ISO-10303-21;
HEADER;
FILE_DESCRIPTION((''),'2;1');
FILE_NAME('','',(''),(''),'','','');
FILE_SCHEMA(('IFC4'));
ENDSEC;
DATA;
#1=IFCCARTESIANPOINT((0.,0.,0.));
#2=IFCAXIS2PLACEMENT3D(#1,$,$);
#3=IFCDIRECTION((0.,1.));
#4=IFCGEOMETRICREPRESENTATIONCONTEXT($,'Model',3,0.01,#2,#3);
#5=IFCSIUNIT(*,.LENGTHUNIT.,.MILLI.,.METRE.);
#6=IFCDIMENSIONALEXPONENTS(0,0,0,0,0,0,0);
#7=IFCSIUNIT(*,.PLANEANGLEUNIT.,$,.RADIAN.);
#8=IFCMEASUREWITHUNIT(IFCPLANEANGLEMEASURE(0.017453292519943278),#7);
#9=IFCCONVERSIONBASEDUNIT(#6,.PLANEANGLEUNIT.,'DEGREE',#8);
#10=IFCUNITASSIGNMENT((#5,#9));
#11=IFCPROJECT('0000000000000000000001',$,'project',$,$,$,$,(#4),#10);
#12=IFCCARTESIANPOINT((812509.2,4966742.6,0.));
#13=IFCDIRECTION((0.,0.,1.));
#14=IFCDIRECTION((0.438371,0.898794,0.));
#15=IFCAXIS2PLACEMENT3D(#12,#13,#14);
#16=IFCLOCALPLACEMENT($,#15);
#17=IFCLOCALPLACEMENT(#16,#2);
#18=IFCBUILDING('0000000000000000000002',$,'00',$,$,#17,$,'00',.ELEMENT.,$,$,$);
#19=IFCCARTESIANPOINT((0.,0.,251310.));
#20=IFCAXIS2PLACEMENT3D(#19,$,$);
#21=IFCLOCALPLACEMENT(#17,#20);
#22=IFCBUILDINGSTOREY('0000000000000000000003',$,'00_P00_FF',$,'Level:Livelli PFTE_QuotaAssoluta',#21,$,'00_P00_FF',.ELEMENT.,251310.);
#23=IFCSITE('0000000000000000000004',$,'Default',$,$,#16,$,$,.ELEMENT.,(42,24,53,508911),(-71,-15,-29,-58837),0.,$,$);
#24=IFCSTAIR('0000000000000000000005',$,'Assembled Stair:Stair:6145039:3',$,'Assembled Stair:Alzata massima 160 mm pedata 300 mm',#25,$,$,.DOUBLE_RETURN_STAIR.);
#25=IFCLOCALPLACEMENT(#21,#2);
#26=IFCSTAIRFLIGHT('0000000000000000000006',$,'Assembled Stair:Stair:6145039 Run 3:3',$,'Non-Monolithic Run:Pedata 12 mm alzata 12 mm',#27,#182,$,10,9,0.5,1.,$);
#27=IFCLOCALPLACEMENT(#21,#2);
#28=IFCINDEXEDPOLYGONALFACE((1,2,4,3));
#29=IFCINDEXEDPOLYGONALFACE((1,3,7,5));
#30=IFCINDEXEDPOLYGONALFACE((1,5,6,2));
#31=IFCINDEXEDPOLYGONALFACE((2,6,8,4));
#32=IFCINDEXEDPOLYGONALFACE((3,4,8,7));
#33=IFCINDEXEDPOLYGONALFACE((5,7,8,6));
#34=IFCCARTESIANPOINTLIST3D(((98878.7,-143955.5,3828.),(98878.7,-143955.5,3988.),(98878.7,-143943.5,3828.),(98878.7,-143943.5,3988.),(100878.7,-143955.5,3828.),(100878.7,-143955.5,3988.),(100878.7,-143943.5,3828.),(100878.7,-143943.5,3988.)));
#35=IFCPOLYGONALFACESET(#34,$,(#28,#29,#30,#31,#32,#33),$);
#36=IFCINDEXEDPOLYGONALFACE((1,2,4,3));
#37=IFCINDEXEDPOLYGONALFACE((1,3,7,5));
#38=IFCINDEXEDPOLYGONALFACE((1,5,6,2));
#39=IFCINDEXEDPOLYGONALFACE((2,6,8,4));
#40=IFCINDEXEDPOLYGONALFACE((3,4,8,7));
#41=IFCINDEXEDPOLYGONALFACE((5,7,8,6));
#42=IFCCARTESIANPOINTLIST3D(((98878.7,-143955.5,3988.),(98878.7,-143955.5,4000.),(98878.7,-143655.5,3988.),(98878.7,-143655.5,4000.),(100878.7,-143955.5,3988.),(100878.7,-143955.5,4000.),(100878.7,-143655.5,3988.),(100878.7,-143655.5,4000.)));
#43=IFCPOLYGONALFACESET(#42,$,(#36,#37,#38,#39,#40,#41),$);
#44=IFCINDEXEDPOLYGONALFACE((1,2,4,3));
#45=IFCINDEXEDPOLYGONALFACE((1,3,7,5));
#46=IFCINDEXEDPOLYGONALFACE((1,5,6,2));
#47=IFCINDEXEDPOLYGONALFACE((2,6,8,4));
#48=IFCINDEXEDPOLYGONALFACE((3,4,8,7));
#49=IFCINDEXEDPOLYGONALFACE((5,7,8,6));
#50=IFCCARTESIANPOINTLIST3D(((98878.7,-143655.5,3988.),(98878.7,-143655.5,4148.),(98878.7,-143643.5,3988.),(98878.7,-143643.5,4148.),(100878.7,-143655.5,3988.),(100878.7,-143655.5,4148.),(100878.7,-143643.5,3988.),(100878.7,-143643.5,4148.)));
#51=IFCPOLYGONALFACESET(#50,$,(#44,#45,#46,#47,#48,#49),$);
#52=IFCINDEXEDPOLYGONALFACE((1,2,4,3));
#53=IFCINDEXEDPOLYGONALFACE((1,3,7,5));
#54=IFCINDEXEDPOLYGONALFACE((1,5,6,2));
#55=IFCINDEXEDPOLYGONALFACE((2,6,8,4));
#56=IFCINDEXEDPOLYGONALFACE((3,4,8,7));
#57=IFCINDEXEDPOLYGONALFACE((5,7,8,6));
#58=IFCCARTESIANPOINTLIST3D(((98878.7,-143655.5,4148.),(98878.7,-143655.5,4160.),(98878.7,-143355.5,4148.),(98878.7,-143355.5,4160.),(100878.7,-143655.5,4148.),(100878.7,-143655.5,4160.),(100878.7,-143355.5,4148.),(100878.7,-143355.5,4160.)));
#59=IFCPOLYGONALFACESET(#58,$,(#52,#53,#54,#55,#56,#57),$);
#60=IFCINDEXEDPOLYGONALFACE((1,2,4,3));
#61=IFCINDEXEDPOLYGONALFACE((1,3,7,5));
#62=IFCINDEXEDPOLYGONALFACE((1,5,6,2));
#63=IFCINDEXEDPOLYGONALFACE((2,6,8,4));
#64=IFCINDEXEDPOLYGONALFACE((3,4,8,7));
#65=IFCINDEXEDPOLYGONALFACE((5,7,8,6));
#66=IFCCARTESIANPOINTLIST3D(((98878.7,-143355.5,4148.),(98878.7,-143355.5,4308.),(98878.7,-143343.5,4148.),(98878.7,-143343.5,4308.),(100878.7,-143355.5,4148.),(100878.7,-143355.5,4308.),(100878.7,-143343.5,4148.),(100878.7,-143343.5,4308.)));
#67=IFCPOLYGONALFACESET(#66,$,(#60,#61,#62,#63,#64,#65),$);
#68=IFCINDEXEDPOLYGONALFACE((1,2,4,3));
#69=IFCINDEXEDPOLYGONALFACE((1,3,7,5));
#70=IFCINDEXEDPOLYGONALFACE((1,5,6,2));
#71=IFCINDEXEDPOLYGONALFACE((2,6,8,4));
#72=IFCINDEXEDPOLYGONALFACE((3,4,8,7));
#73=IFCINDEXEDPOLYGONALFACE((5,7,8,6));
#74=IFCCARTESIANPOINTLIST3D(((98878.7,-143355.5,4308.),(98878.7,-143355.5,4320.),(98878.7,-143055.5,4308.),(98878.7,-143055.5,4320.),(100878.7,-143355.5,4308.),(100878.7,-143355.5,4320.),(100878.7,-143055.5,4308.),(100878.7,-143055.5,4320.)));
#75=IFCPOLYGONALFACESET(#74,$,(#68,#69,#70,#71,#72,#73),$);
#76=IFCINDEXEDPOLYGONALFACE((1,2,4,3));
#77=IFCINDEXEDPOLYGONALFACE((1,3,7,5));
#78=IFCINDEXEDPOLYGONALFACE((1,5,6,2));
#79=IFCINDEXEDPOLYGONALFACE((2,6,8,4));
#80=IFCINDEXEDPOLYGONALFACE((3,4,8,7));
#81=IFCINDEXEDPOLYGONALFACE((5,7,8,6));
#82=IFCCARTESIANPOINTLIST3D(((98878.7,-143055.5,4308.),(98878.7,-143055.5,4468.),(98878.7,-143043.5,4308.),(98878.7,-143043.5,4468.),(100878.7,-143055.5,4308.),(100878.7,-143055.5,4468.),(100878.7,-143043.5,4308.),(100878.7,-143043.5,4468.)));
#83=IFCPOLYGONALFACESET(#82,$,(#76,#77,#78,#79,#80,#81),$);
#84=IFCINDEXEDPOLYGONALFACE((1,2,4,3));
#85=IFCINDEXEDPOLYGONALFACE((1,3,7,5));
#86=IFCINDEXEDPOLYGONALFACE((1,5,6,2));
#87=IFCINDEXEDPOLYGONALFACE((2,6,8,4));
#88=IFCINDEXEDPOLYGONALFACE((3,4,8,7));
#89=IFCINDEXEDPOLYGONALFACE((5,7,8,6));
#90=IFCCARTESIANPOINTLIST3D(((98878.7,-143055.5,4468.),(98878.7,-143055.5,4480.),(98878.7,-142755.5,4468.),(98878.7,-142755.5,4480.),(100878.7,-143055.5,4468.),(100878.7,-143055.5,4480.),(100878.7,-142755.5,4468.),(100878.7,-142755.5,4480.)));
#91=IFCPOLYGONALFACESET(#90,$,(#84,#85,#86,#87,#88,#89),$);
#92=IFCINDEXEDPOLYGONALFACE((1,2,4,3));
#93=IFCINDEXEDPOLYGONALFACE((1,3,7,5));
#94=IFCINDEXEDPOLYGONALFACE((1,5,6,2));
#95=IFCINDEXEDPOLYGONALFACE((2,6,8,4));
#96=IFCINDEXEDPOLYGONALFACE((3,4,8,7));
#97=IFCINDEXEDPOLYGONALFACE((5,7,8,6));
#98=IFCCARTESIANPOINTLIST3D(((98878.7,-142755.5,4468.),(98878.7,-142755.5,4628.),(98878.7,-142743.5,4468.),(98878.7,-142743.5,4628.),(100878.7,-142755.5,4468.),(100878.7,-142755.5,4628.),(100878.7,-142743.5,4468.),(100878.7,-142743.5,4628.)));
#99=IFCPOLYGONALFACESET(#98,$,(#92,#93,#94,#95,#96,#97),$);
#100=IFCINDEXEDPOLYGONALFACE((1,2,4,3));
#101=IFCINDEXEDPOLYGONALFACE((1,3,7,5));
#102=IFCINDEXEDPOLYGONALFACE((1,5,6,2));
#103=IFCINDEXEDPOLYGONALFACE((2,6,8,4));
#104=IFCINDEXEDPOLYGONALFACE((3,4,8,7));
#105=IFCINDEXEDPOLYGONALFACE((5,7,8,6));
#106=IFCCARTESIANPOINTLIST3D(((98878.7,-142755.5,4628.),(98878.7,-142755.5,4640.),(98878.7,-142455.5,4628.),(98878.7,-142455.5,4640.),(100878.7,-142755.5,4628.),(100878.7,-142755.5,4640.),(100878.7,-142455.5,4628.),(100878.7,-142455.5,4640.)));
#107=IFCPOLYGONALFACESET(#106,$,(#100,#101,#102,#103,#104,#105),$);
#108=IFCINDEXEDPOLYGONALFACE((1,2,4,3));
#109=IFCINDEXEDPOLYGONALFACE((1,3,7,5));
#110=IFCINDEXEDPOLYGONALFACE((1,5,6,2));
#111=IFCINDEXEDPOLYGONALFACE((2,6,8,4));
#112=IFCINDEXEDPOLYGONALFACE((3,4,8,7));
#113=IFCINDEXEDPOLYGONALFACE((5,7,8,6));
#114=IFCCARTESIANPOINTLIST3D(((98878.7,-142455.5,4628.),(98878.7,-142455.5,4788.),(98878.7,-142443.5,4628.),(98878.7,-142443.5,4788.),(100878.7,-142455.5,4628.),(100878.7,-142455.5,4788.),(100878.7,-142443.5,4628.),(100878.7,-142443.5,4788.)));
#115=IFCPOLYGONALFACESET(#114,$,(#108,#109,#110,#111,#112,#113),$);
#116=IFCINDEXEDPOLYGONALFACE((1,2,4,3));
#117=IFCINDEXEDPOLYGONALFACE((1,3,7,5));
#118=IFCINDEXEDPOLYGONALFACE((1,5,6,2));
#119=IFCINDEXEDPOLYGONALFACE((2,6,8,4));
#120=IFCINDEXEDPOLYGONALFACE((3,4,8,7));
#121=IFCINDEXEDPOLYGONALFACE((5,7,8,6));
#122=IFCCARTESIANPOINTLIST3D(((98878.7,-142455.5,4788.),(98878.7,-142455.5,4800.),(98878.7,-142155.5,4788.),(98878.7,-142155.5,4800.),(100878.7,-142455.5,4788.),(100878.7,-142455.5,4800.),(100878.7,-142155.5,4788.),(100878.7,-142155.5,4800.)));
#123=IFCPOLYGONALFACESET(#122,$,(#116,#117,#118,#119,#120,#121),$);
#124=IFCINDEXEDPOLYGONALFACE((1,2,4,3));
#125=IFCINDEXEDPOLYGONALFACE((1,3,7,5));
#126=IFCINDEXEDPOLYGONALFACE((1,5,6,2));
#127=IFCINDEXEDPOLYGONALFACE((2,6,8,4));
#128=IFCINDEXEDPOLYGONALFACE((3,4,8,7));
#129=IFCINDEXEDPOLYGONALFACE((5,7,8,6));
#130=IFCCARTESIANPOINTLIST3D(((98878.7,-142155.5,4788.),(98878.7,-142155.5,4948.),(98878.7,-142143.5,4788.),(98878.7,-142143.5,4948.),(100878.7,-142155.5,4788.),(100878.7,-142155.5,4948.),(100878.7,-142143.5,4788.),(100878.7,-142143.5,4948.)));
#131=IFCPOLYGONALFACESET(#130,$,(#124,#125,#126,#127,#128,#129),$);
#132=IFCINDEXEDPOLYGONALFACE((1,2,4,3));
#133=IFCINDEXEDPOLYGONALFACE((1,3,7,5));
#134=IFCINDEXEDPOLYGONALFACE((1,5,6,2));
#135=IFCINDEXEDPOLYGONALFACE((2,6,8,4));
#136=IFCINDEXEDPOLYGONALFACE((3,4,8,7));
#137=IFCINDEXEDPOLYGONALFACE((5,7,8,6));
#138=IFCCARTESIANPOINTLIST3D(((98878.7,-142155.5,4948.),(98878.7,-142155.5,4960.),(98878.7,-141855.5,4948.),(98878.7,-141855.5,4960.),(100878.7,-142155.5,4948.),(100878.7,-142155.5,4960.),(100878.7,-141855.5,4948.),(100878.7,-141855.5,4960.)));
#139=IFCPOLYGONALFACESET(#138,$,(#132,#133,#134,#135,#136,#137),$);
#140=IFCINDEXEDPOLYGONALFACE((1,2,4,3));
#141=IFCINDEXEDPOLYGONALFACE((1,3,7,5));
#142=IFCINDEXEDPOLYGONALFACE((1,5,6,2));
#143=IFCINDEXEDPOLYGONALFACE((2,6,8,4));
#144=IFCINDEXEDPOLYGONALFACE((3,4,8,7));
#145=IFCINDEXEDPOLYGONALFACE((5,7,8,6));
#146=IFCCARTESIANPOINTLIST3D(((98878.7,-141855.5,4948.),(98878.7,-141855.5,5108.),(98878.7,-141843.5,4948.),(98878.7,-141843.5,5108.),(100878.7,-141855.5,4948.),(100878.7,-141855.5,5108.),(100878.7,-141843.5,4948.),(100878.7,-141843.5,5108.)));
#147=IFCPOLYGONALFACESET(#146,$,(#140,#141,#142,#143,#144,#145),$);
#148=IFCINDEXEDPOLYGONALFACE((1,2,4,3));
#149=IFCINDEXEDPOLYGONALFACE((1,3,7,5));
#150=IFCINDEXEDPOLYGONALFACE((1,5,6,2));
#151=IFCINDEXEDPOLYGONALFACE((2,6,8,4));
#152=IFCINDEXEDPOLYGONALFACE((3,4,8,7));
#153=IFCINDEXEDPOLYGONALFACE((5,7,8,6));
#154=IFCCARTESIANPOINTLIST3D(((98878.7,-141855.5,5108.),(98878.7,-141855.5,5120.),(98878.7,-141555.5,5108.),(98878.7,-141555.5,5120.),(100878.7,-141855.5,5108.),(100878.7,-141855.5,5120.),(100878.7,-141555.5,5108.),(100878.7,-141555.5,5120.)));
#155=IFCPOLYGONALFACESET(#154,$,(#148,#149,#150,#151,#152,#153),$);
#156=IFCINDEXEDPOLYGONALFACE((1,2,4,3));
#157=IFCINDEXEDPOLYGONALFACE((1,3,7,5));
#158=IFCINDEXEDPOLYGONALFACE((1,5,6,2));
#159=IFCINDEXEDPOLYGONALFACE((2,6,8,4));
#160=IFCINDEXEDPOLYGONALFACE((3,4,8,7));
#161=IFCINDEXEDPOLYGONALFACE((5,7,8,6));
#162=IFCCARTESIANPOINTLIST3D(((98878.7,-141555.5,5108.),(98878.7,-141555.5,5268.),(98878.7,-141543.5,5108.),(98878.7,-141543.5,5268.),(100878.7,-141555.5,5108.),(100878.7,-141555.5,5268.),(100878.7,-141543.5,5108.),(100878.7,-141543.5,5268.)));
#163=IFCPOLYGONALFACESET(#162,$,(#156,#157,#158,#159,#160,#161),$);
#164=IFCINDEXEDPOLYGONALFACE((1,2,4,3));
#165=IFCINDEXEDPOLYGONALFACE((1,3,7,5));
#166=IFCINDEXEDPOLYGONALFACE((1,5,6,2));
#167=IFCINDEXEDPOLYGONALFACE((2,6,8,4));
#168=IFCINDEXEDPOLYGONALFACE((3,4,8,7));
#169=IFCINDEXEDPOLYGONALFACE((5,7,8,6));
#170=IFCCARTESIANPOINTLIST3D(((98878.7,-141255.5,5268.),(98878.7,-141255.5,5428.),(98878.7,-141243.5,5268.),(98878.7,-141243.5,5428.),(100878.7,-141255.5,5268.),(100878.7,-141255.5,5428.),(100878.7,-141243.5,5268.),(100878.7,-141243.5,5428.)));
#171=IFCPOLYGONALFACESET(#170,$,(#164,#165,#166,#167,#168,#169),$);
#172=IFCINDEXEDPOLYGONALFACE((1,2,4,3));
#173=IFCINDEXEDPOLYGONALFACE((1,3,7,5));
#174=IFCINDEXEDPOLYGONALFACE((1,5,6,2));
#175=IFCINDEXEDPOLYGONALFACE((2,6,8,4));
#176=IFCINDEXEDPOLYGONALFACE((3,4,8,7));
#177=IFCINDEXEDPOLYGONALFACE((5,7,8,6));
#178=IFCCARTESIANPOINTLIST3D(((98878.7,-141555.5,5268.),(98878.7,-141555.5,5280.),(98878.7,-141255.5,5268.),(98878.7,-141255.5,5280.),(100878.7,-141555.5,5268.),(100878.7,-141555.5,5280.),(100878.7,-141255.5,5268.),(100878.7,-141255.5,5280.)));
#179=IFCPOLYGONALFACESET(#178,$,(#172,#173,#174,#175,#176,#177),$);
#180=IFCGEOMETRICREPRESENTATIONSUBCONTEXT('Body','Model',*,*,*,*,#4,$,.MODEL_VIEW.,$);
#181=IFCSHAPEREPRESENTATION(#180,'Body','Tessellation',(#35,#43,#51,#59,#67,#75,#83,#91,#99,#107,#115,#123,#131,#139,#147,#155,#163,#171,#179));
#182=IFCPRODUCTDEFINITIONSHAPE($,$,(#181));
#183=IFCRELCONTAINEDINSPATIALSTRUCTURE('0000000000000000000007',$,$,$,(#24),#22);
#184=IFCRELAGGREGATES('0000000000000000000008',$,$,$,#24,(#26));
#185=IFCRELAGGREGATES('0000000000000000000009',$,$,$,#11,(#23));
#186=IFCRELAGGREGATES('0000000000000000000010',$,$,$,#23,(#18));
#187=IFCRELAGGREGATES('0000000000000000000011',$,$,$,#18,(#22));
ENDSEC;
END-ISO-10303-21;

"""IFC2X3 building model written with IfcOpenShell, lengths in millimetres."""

from ifc_helpers import new_model, entity, si_unit, converted_unit, direction, frame, origin, origin_2d_with_axis, place, context, subcontext, project, spatial, rectangle, extrude, element, aggregate, save


model = new_model("IFC2X3")

# Units and contexts
model_context = context("Model", 3, precision=0.01, world=origin(), true_north=direction((0.0, 1.0)))
body_context = subcontext(model_context, "Body", "Model", "MODEL_VIEW")
ifc_project = project(units=[si_unit("LENGTHUNIT", "METRE", prefix="MILLI"), converted_unit("PLANEANGLEUNIT", "DEGREE", entity("IfcPlaneAngleMeasure", 0.017453292519943278), si_unit("PLANEANGLEUNIT", "RADIAN"), dimensions=[0, 0, 0, 0, 0, 0, 0])], contexts=[model_context])

# Site, building, storey
site_placement = place(None, frame((812509.2, 4966742.6, 0.0), z_axis=(0.0, 0.0, 1.0), x_axis=(0.438371, 0.898794, 0.0)))
site = spatial("IfcSite", under=ifc_project, at=site_placement, Name="Default", CompositionType="ELEMENT", RefLatitude=(42, 24, 53, 508911), RefLongitude=(-71, -15, -29, -58837), RefElevation=0.0)
building_placement = place(site_placement, origin())
building = spatial("IfcBuilding", under=site, at=building_placement, Name="00", LongName="00", CompositionType="ELEMENT")
storey_placement = place(building_placement, frame((0.0, 0.0, 251310.0)))
storey = spatial("IfcBuildingStorey", under=building, at=storey_placement, Name="00_P00_FF", ObjectType="Level:Livelli PFTE_QuotaAssoluta", LongName="00_P00_FF", CompositionType="ELEMENT", Elevation=251310.0)

# Stair
stair_1_placement = place(storey_placement, origin())
stair_1 = element("IfcStair", 1, at=stair_1_placement, inside=storey, Name="Assembled Stair:Stair:6145039:3", ObjectType="Assembled Stair:Alzata massima 160 mm pedata 300 mm", ShapeType="DOUBLE_RETURN_STAIR")

# Stair flight
stair_flight_1_placement = place(stair_1_placement, origin())
stair_flight_1 = element("IfcStairFlight", 2, at=stair_flight_1_placement, Name="Assembled Stair:Stair:6145039 Run 3:3", ObjectType="Non-Monolithic Run:Pedata 12 mm alzata 12 mm", NumberOfRiser=10, NumberOfTreads=9, RiserHeight=0.5, TreadLength=1.0, context=body_context, shape_type="SweptSolid", body=[
    extrude(rectangle(XDim=2000.0, YDim=12.0, at=origin_2d_with_axis()), frame((99878.7, -143949.5, 3828.0), z_axis=(0.0, 0.0, 1.0), x_axis=(-1.0, 0.0, 0.0)), (0.0, 0.0, 1.0), 160.0),
    extrude(rectangle(XDim=300.0, YDim=2000.0, at=origin_2d_with_axis()), frame((99878.7, -143805.5, 3988.0), z_axis=(0.0, 0.0, 1.0), x_axis=(0.0, -1.0, 0.0)), (0.0, 0.0, 1.0), 12.0),
    extrude(rectangle(XDim=2000.0, YDim=12.0, at=origin_2d_with_axis()), frame((99878.7, -143649.5, 3988.0), z_axis=(0.0, 0.0, 1.0), x_axis=(-1.0, 0.0, 0.0)), (0.0, 0.0, 1.0), 160.0),
    extrude(rectangle(XDim=300.0, YDim=2000.0, at=origin_2d_with_axis()), frame((99878.7, -143505.5, 4148.0), z_axis=(0.0, 0.0, 1.0), x_axis=(0.0, -1.0, 0.0)), (0.0, 0.0, 1.0), 12.0),
    extrude(rectangle(XDim=2000.0, YDim=12.0, at=origin_2d_with_axis()), frame((99878.7, -143349.5, 4148.0), z_axis=(0.0, 0.0, 1.0), x_axis=(-1.0, 0.0, 0.0)), (0.0, 0.0, 1.0), 160.0),
    extrude(rectangle(XDim=300.0, YDim=2000.0, at=origin_2d_with_axis()), frame((99878.7, -143205.5, 4308.0), z_axis=(0.0, 0.0, 1.0), x_axis=(0.0, -1.0, 0.0)), (0.0, 0.0, 1.0), 12.0),
    extrude(rectangle(XDim=2000.0, YDim=12.0, at=origin_2d_with_axis()), frame((99878.7, -143049.5, 4308.0), z_axis=(0.0, 0.0, 1.0), x_axis=(-1.0, 0.0, 0.0)), (0.0, 0.0, 1.0), 160.0),
    extrude(rectangle(XDim=300.0, YDim=2000.0, at=origin_2d_with_axis()), frame((99878.7, -142905.5, 4468.0), z_axis=(0.0, 0.0, 1.0), x_axis=(0.0, -1.0, 0.0)), (0.0, 0.0, 1.0), 12.0),
    extrude(rectangle(XDim=2000.0, YDim=12.0, at=origin_2d_with_axis()), frame((99878.7, -142749.5, 4468.0), z_axis=(0.0, 0.0, 1.0), x_axis=(-1.0, 0.0, 0.0)), (0.0, 0.0, 1.0), 160.0),
    extrude(rectangle(XDim=300.0, YDim=2000.0, at=origin_2d_with_axis()), frame((99878.7, -142605.5, 4628.0), z_axis=(0.0, 0.0, 1.0), x_axis=(0.0, -1.0, 0.0)), (0.0, 0.0, 1.0), 12.0),
    extrude(rectangle(XDim=2000.0, YDim=12.0, at=origin_2d_with_axis()), frame((99878.7, -142449.5, 4628.0), z_axis=(0.0, 0.0, 1.0), x_axis=(-1.0, 0.0, 0.0)), (0.0, 0.0, 1.0), 160.0),
    extrude(rectangle(XDim=300.0, YDim=2000.0, at=origin_2d_with_axis()), frame((99878.7, -142305.5, 4788.0), z_axis=(0.0, 0.0, 1.0), x_axis=(0.0, -1.0, 0.0)), (0.0, 0.0, 1.0), 12.0),
    extrude(rectangle(XDim=2000.0, YDim=12.0, at=origin_2d_with_axis()), frame((99878.7, -142149.5, 4788.0), z_axis=(0.0, 0.0, 1.0), x_axis=(-1.0, 0.0, 0.0)), (0.0, 0.0, 1.0), 160.0),
    extrude(rectangle(XDim=300.0, YDim=2000.0, at=origin_2d_with_axis()), frame((99878.7, -142005.5, 4948.0), z_axis=(0.0, 0.0, 1.0), x_axis=(0.0, -1.0, 0.0)), (0.0, 0.0, 1.0), 12.0),
    extrude(rectangle(XDim=2000.0, YDim=12.0, at=origin_2d_with_axis()), frame((99878.7, -141849.5, 4948.0), z_axis=(0.0, 0.0, 1.0), x_axis=(-1.0, 0.0, 0.0)), (0.0, 0.0, 1.0), 160.0),
    extrude(rectangle(XDim=300.0, YDim=2000.0, at=origin_2d_with_axis()), frame((99878.7, -141705.5, 5108.0), z_axis=(0.0, 0.0, 1.0), x_axis=(0.0, -1.0, 0.0)), (0.0, 0.0, 1.0), 12.0),
    extrude(rectangle(XDim=2000.0, YDim=12.0, at=origin_2d_with_axis()), frame((99878.7, -141549.5, 5108.0), z_axis=(0.0, 0.0, 1.0), x_axis=(-1.0, 0.0, 0.0)), (0.0, 0.0, 1.0), 160.0),
    extrude(rectangle(XDim=2000.0, YDim=12.0, at=origin_2d_with_axis()), frame((99878.7, -141249.5, 5268.0), z_axis=(0.0, 0.0, 1.0), x_axis=(-1.0, 0.0, 0.0)), (0.0, 0.0, 1.0), 160.0),
    extrude(rectangle(XDim=300.0, YDim=2000.0, at=origin_2d_with_axis()), frame((99878.7, -141405.5, 5268.0), z_axis=(0.0, 0.0, 1.0), x_axis=(0.0, -1.0, 0.0)), (0.0, 0.0, 1.0), 12.0),
])
aggregate(stair_1, [stair_flight_1])

save(model, "model.ifc")
